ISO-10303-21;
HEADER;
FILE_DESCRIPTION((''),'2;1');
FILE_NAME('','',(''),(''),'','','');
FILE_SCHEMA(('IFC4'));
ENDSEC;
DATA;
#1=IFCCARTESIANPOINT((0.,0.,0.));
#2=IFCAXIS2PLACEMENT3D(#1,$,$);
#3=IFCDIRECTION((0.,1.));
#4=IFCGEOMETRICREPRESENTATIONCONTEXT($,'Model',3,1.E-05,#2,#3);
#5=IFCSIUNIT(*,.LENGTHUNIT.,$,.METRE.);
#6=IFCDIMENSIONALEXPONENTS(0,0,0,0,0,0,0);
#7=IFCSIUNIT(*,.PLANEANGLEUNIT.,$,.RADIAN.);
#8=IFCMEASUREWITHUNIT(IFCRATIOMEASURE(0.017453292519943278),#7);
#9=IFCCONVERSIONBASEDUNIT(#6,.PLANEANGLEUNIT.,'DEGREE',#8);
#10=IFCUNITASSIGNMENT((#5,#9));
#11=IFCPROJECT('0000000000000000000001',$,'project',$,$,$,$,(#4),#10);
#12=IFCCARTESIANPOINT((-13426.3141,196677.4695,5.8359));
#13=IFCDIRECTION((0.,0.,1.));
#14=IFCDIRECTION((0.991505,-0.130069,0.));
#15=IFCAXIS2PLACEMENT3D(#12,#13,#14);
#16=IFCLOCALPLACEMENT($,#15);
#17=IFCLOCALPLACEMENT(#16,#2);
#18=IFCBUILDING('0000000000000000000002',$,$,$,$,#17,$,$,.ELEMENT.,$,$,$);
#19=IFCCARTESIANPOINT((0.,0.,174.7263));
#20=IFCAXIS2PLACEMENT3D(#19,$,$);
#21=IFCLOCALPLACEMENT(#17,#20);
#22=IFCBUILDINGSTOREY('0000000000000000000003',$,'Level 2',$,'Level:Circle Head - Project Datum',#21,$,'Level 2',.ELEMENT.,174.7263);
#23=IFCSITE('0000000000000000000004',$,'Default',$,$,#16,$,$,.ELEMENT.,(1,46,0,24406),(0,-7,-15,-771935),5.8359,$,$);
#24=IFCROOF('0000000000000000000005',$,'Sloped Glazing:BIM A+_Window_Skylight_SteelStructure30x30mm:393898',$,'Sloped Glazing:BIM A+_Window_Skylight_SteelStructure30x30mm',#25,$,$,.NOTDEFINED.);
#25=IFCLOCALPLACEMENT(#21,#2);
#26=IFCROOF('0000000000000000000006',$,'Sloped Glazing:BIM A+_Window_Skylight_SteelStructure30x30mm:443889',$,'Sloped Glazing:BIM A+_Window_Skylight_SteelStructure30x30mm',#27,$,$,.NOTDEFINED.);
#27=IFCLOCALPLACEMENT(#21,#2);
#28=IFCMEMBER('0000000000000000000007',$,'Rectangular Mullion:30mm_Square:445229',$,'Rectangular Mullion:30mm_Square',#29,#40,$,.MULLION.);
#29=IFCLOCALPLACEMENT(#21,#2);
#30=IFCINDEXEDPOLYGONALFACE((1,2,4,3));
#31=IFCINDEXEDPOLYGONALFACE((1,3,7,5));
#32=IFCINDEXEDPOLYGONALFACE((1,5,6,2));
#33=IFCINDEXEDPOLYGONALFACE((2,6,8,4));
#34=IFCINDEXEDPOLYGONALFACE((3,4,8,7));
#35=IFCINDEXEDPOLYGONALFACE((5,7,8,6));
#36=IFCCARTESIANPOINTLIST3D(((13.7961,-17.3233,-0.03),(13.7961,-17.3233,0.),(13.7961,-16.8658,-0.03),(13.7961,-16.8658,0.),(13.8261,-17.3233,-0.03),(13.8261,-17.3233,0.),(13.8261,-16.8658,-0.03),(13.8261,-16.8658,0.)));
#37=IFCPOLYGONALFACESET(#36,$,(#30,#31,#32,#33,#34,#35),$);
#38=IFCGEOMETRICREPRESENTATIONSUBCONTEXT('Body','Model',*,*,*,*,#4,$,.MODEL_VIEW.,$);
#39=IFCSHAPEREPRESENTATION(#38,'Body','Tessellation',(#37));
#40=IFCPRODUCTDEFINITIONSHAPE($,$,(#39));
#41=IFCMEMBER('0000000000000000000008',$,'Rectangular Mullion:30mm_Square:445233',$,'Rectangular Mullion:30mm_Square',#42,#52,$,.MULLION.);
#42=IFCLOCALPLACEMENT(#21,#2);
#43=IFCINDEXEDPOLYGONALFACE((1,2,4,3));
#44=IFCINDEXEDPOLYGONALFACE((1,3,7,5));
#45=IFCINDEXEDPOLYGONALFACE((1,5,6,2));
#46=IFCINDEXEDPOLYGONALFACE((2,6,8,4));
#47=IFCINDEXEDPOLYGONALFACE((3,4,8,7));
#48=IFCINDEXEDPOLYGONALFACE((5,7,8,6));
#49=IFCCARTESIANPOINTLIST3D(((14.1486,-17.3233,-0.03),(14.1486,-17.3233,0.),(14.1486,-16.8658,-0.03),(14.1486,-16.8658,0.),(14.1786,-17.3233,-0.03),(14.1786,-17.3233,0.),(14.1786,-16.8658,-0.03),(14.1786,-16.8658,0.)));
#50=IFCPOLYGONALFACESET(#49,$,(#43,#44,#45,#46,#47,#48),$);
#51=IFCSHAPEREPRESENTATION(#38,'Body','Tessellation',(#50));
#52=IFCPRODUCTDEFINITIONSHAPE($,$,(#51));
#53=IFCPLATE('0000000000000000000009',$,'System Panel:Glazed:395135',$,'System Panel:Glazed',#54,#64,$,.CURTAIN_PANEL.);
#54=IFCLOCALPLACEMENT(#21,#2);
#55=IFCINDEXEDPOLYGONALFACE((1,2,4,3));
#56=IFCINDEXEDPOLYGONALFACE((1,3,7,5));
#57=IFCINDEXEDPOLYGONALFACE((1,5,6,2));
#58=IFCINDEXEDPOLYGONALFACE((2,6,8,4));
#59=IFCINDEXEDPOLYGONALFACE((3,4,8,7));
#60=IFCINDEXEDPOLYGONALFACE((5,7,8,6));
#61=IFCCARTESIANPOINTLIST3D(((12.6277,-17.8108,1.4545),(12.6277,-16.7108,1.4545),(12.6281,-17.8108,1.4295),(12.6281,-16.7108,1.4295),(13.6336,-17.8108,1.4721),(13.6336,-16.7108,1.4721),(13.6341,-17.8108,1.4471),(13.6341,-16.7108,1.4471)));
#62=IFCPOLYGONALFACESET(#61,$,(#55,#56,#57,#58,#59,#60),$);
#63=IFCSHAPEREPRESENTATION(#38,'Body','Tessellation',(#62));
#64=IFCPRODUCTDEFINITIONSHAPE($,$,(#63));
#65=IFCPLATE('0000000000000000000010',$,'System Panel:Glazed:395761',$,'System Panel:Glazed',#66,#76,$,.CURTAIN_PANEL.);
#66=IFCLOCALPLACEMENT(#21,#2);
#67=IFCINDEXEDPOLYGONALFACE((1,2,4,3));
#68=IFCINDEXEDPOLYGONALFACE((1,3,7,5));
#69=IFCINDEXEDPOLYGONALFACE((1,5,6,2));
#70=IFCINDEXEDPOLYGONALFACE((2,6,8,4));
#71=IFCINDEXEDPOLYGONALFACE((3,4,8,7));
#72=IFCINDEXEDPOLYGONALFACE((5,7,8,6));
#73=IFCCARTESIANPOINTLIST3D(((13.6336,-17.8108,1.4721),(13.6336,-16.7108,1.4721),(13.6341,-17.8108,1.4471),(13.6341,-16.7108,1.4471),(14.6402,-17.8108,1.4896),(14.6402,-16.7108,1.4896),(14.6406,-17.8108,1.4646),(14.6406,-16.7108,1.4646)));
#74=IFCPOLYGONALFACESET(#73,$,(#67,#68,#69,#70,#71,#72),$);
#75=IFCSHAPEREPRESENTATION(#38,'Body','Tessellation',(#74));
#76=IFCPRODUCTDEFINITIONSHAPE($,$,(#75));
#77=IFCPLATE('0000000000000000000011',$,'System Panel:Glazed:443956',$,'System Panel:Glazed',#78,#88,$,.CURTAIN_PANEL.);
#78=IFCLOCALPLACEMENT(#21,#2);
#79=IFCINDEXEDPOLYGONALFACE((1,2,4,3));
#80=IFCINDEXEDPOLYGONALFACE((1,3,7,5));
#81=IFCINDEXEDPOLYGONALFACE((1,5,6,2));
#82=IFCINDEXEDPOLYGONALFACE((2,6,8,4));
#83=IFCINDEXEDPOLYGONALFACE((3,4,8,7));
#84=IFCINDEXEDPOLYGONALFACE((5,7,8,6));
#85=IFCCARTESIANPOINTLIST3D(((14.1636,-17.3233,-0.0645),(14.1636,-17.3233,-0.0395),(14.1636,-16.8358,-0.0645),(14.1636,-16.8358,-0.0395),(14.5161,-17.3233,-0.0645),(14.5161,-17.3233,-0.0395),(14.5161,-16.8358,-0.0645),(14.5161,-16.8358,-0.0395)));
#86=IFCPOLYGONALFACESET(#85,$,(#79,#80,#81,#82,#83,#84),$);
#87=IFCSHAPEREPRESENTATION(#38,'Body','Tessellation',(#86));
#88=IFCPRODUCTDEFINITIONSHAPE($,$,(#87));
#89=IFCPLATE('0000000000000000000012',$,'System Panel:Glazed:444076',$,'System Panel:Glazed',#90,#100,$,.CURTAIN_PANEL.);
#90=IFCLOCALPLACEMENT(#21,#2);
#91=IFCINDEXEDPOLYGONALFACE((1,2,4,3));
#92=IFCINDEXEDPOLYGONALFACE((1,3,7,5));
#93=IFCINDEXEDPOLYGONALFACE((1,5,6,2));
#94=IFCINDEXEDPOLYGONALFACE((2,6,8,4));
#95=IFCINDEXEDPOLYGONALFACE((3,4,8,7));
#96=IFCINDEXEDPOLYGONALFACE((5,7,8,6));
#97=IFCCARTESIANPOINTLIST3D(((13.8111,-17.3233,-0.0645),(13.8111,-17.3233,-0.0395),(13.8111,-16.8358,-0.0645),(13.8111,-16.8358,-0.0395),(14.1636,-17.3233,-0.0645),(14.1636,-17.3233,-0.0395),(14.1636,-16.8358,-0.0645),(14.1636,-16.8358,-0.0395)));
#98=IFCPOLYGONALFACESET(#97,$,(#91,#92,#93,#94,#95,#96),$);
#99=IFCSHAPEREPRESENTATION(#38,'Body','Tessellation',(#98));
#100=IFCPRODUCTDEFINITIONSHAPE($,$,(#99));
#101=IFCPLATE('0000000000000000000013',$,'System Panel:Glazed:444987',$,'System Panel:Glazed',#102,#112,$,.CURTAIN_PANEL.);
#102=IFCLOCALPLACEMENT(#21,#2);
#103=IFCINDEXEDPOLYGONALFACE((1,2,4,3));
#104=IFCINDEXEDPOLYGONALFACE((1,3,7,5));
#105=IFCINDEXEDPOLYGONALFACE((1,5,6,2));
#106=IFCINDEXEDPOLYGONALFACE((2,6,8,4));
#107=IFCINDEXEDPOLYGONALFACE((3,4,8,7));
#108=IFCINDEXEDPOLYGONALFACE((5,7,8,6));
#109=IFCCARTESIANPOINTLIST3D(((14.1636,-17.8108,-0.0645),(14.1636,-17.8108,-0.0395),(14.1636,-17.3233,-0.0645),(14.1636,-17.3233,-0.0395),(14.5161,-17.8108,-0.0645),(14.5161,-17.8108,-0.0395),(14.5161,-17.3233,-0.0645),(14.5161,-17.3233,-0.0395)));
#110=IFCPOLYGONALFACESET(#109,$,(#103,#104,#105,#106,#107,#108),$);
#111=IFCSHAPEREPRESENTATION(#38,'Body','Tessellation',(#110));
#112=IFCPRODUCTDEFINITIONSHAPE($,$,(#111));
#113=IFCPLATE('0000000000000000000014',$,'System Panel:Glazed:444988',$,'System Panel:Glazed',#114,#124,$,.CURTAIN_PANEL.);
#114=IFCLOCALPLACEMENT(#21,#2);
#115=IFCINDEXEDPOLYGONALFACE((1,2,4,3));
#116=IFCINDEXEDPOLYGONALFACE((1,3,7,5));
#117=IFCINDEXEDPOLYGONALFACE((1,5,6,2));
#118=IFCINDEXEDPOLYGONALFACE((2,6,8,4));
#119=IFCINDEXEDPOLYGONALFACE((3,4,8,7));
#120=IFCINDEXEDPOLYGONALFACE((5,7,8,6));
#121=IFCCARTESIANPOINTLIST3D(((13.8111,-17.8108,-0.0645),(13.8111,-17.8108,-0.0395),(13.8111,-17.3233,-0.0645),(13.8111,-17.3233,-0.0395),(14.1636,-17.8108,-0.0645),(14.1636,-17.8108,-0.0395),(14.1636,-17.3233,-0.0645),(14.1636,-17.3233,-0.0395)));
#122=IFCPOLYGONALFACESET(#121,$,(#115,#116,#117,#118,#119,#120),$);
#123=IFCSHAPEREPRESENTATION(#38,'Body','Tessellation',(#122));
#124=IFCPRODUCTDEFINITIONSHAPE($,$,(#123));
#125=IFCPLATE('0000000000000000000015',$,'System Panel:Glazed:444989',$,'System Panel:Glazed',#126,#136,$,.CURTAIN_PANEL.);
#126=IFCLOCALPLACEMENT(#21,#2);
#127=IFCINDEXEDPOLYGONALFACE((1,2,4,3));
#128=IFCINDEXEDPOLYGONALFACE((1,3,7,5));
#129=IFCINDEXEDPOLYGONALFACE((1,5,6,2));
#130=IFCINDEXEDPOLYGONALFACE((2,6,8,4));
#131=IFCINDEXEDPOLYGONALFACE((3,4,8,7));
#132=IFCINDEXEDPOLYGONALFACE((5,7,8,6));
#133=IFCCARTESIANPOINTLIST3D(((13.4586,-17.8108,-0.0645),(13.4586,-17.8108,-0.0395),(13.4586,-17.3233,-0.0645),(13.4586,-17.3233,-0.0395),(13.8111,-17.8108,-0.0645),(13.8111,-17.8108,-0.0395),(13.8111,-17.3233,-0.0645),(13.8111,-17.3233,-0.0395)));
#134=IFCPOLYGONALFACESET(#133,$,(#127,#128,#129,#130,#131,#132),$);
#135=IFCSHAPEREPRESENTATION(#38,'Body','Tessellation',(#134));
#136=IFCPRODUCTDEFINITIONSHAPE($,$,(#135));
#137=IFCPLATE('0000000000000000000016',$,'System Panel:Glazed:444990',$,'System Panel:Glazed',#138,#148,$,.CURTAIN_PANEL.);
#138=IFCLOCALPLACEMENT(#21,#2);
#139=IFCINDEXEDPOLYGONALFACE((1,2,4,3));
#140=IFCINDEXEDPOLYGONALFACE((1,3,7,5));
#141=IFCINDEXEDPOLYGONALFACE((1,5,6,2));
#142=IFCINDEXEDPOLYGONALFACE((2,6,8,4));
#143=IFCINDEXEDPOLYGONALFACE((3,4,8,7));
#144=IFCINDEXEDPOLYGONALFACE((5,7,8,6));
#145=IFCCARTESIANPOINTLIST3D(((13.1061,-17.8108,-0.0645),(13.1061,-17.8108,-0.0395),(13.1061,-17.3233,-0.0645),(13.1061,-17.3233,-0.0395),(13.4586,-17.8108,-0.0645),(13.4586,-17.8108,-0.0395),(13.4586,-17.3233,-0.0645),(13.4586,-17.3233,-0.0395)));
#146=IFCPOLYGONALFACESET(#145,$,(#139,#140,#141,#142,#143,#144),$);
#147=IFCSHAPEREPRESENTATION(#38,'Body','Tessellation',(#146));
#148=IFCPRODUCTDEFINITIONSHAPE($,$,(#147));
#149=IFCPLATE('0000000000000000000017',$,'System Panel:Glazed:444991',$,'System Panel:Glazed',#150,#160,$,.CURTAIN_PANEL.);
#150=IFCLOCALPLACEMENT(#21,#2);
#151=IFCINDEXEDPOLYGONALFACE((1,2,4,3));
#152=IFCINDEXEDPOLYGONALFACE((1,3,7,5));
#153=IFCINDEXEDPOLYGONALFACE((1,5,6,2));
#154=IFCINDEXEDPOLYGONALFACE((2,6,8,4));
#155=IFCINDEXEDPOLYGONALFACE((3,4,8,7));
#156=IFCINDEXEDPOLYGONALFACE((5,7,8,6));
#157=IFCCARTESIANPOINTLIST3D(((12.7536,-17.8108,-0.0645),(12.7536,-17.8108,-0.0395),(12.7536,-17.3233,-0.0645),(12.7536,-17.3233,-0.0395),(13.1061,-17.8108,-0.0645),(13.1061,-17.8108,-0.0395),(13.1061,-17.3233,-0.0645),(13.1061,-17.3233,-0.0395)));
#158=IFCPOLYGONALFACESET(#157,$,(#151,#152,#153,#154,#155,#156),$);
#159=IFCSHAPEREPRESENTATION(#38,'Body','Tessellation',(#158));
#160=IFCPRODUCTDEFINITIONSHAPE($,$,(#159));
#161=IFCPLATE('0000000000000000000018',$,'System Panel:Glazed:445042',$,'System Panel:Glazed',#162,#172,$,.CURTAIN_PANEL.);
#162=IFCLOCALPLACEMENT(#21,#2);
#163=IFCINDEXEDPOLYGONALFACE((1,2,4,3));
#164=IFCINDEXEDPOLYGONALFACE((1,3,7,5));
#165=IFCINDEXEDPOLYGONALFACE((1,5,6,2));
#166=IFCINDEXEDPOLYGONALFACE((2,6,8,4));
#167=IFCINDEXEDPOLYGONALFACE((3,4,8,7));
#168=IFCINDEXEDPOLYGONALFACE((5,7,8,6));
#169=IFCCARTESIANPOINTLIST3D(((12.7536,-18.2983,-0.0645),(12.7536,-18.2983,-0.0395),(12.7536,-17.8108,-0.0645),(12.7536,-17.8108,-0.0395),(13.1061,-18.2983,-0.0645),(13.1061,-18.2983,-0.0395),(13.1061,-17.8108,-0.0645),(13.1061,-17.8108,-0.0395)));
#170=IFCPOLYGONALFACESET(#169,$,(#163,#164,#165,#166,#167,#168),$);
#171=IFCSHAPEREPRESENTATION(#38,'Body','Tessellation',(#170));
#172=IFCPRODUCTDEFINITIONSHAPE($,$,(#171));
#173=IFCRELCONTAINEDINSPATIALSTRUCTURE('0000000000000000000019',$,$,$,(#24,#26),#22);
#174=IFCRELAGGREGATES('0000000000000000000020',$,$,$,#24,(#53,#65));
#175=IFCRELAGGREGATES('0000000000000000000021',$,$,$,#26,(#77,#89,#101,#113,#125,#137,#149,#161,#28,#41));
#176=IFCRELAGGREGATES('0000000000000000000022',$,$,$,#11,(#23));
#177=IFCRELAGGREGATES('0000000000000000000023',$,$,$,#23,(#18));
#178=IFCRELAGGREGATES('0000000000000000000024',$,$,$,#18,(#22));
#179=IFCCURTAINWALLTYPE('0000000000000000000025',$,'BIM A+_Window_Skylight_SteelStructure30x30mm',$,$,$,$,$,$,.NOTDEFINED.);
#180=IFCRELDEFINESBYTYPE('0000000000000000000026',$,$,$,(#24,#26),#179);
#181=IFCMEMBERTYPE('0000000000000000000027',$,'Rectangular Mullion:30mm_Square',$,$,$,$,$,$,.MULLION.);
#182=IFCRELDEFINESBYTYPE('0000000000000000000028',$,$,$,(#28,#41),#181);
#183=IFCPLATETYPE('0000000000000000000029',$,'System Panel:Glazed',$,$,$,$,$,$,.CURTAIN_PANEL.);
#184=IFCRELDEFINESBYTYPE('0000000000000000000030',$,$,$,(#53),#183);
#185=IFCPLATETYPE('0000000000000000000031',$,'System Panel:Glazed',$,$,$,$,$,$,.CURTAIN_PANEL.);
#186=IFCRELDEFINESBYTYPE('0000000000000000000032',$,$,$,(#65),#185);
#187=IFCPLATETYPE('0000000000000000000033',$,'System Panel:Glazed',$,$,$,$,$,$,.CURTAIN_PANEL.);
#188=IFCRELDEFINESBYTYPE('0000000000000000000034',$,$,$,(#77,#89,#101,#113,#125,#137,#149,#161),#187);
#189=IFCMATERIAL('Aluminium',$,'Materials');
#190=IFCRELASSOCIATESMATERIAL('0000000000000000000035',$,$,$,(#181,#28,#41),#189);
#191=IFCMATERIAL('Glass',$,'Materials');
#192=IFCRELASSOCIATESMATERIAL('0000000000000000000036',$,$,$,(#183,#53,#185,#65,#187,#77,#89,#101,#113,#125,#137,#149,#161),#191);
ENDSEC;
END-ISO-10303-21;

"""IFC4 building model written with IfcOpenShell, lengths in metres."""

from ifc_helpers import new_model, entity, si_unit, converted_unit, direction, frame, origin, place, context, subcontext, project, spatial, indexed_curve, outline, extrude, source, transform, mapped, material, type_object, type_shapes, element, aggregate, save


model = new_model("IFC4")

# Units and contexts
model_context = context("Model", 3, precision=1e-05, world=origin(), true_north=direction((0.0, 1.0)))
body_context = subcontext(model_context, "Body", "Model", "MODEL_VIEW")
ifc_project = project(units=[si_unit("LENGTHUNIT", "METRE"), converted_unit("PLANEANGLEUNIT", "DEGREE", entity("IfcRatioMeasure", 0.017453292519943278), si_unit("PLANEANGLEUNIT", "RADIAN"), dimensions=[0, 0, 0, 0, 0, 0, 0])], contexts=[model_context])

# Site, building, storey
site_placement = place(None, frame((-13426.3141, 196677.4695, 5.8359), z_axis=(0.0, 0.0, 1.0), x_axis=(0.991505, -0.130069, 0.0)))
site = spatial("IfcSite", under=ifc_project, at=site_placement, Name="Default", CompositionType="ELEMENT", RefLatitude=(1, 46, 0, 24406), RefLongitude=(0, -7, -15, -771935), RefElevation=5.8359)
building_placement = place(site_placement, origin())
building = spatial("IfcBuilding", under=site, at=building_placement, CompositionType="ELEMENT")
storey_placement = place(building_placement, frame((0.0, 0.0, 174.7263)))
storey = spatial("IfcBuildingStorey", under=building, at=storey_placement, Name="Level 2", ObjectType="Level:Circle Head - Project Datum", LongName="Level 2", CompositionType="ELEMENT", Elevation=174.7263)

# Roofs, members
curtain_wall_type = type_object("IfcCurtainWallType", Name="BIM A+_Window_Skylight_SteelStructure30x30mm", PredefinedType="NOTDEFINED")
roof_1_placement = place(storey_placement, frame((0.0, 0.0, -174.7263)))
roof_1 = element("IfcRoof", 1, at=roof_1_placement, inside=storey, type_object=curtain_wall_type, Name="Sloped Glazing:BIM A+_Window_Skylight_SteelStructure30x30mm:393898", ObjectType="Sloped Glazing:BIM A+_Window_Skylight_SteelStructure30x30mm", PredefinedType="NOTDEFINED")
ifc_material_1 = material(Name="Aluminium", Category="Materials")
roof_2_placement = place(storey_placement, frame((0.0, 0.0, -174.7263)))
roof_2 = element("IfcRoof", 2, at=roof_2_placement, inside=storey, type_object=curtain_wall_type, Name="Sloped Glazing:BIM A+_Window_Skylight_SteelStructure30x30mm:443889", ObjectType="Sloped Glazing:BIM A+_Window_Skylight_SteelStructure30x30mm", PredefinedType="NOTDEFINED")
member_type_1 = type_object("IfcMemberType", Name="Rectangular Mullion:30mm_Square", PredefinedType="MULLION", material=ifc_material_1)
shared_shape_1 = source(origin(), body_context, "Body", "SweptSolid", [
    extrude(outline(indexed_curve([(-0.015, -0.015), (0.015, -0.015), (0.015, 0.015), (-0.015, 0.015), (-0.015, -0.015)], self_intersect=False)), frame((0.0, 0.0, -0.4575), z_axis=(0.0, 0.0, 1.0), x_axis=(0.0, -1.0, 0.0)), (0.0, 0.0, 1.0), 0.4575),
])
type_shapes(member_type_1, [shared_shape_1])
member_1_placement = place(roof_2_placement, frame((13.8111, -17.3233, 174.7113), z_axis=(0.0, -1.0, 0.0), x_axis=(-1.0, 0.0, 0.0)))
member_1 = element("IfcMember", 3, at=member_1_placement, type_object=member_type_1, material=ifc_material_1, Name="Rectangular Mullion:30mm_Square:445229", ObjectType="Rectangular Mullion:30mm_Square", PredefinedType="MULLION", context=body_context, shape_type="MappedRepresentation", body=[
    mapped(shared_shape_1, transform((0.0, 0.0, 0.0), scale=1.0)),
])
member_2_placement = place(roof_2_placement, frame((14.1636, -17.3233, 174.7113), z_axis=(0.0, -1.0, 0.0), x_axis=(-1.0, 0.0, 0.0)))
member_2 = element("IfcMember", 4, at=member_2_placement, type_object=member_type_1, material=ifc_material_1, Name="Rectangular Mullion:30mm_Square:445233", ObjectType="Rectangular Mullion:30mm_Square", PredefinedType="MULLION", context=body_context, shape_type="MappedRepresentation", body=[
    mapped(shared_shape_1, transform((0.0, 0.0, 0.0), scale=1.0)),
])

# Plates
ifc_material_2 = material(Name="Glass", Category="Materials")
plate_type_1 = type_object("IfcPlateType", Name="System Panel:Glazed", PredefinedType="CURTAIN_PANEL", material=ifc_material_2)
shared_shape_2 = source(origin(), body_context, "Body", "SweptSolid", [
    extrude(outline(indexed_curve([(-0.0125, -0.55), (0.0125, -0.55), (0.0125, 0.55), (-0.0125, 0.55), (-0.0125, -0.55)], self_intersect=False)), frame((0.0, 0.037, 0.0), z_axis=(0.0, 0.0, 1.0), x_axis=(0.0, 1.0, 0.0)), (0.0, 0.0, 1.0), 1.0061),
])
type_shapes(plate_type_1, [shared_shape_2])
plate_1_placement = place(roof_1_placement, frame((12.6286, -17.2608, 176.1313), z_axis=(0.999848, 0.0, 0.017452), x_axis=(0.0, 1.0, 0.0)))
plate_1 = element("IfcPlate", 5, at=plate_1_placement, type_object=plate_type_1, material=ifc_material_2, Name="System Panel:Glazed:395135", ObjectType="System Panel:Glazed", PredefinedType="CURTAIN_PANEL", context=body_context, shape_type="MappedRepresentation", body=[
    mapped(shared_shape_2, transform((0.0, 0.0, 0.0), scale=1.0)),
])
plate_type_2 = type_object("IfcPlateType", Name="System Panel:Glazed", PredefinedType="CURTAIN_PANEL", material=ifc_material_2)
shared_shape_3 = source(origin(), body_context, "Body", "SweptSolid", [
    extrude(outline(indexed_curve([(-0.0125, -0.55), (0.0125, -0.55), (0.0125, 0.55), (-0.0125, 0.55), (-0.0125, -0.55)], self_intersect=False)), frame((0.0, 0.037, 0.0), z_axis=(0.0, 0.0, 1.0), x_axis=(0.0, 1.0, 0.0)), (0.0, 0.0, 1.0), 1.0067),
])
type_shapes(plate_type_2, [shared_shape_3])
plate_2_placement = place(roof_1_placement, frame((13.6345, -17.2608, 176.1489), z_axis=(0.999848, 0.0, 0.017452), x_axis=(0.0, 1.0, 0.0)))
plate_2 = element("IfcPlate", 6, at=plate_2_placement, type_object=plate_type_2, material=ifc_material_2, Name="System Panel:Glazed:395761", ObjectType="System Panel:Glazed", PredefinedType="CURTAIN_PANEL", context=body_context, shape_type="MappedRepresentation", body=[
    mapped(shared_shape_3, transform((0.0, 0.0, 0.0), scale=1.0)),
])
aggregate(roof_1, [plate_1, plate_2])
plate_type_3 = type_object("IfcPlateType", Name="System Panel:Glazed", PredefinedType="CURTAIN_PANEL", material=ifc_material_2)
shared_shape_4 = source(origin(), body_context, "Body", "SweptSolid", [
    extrude(outline(indexed_curve([(-0.0125, -0.1762), (0.0125, -0.1762), (0.0125, 0.1762), (-0.0125, 0.1762), (-0.0125, -0.1762)], self_intersect=False)), frame((0.0, 0.037, 0.0), z_axis=(0.0, 0.0, 1.0), x_axis=(0.0, 1.0, 0.0)), (0.0, 0.0, 1.0), 0.4875),
])
type_shapes(plate_type_3, [shared_shape_4])
plate_3_placement = place(roof_2_placement, frame((14.3398, -16.8358, 174.7113), z_axis=(0.0, -1.0, 0.0), x_axis=(-1.0, 0.0, 0.0)))
plate_3 = element("IfcPlate", 7, at=plate_3_placement, type_object=plate_type_3, material=ifc_material_2, Name="System Panel:Glazed:443956", ObjectType="System Panel:Glazed", PredefinedType="CURTAIN_PANEL", context=body_context, shape_type="MappedRepresentation", body=[
    mapped(shared_shape_4, transform((0.0, 0.0, 0.0), scale=1.0)),
])
plate_4_placement = place(roof_2_placement, frame((13.9873, -16.8358, 174.7113), z_axis=(0.0, -1.0, 0.0), x_axis=(-1.0, 0.0, 0.0)))
plate_4 = element("IfcPlate", 8, at=plate_4_placement, type_object=plate_type_3, material=ifc_material_2, Name="System Panel:Glazed:444076", ObjectType="System Panel:Glazed", PredefinedType="CURTAIN_PANEL", context=body_context, shape_type="MappedRepresentation", body=[
    mapped(shared_shape_4, transform((0.0, 0.0, 0.0), scale=1.0)),
])
plate_5_placement = place(roof_2_placement, frame((14.3398, -17.3233, 174.7113), z_axis=(0.0, -1.0, 0.0), x_axis=(-1.0, 0.0, 0.0)))
plate_5 = element("IfcPlate", 9, at=plate_5_placement, type_object=plate_type_3, material=ifc_material_2, Name="System Panel:Glazed:444987", ObjectType="System Panel:Glazed", PredefinedType="CURTAIN_PANEL", context=body_context, shape_type="MappedRepresentation", body=[
    mapped(shared_shape_4, transform((0.0, 0.0, 0.0), scale=1.0)),
])
plate_6_placement = place(roof_2_placement, frame((13.9873, -17.3233, 174.7113), z_axis=(0.0, -1.0, 0.0), x_axis=(-1.0, 0.0, 0.0)))
plate_6 = element("IfcPlate", 10, at=plate_6_placement, type_object=plate_type_3, material=ifc_material_2, Name="System Panel:Glazed:444988", ObjectType="System Panel:Glazed", PredefinedType="CURTAIN_PANEL", context=body_context, shape_type="MappedRepresentation", body=[
    mapped(shared_shape_4, transform((0.0, 0.0, 0.0), scale=1.0)),
])
plate_7_placement = place(roof_2_placement, frame((13.6348, -17.3233, 174.7113), z_axis=(0.0, -1.0, 0.0), x_axis=(-1.0, 0.0, 0.0)))
plate_7 = element("IfcPlate", 11, at=plate_7_placement, type_object=plate_type_3, material=ifc_material_2, Name="System Panel:Glazed:444989", ObjectType="System Panel:Glazed", PredefinedType="CURTAIN_PANEL", context=body_context, shape_type="MappedRepresentation", body=[
    mapped(shared_shape_4, transform((0.0, 0.0, 0.0), scale=1.0)),
])
plate_8_placement = place(roof_2_placement, frame((13.2823, -17.3233, 174.7113), z_axis=(0.0, -1.0, 0.0), x_axis=(-1.0, 0.0, 0.0)))
plate_8 = element("IfcPlate", 12, at=plate_8_placement, type_object=plate_type_3, material=ifc_material_2, Name="System Panel:Glazed:444990", ObjectType="System Panel:Glazed", PredefinedType="CURTAIN_PANEL", context=body_context, shape_type="MappedRepresentation", body=[
    mapped(shared_shape_4, transform((0.0, 0.0, 0.0), scale=1.0)),
])
plate_9_placement = place(roof_2_placement, frame((12.9298, -17.3233, 174.7113), z_axis=(0.0, -1.0, 0.0), x_axis=(-1.0, 0.0, 0.0)))
plate_9 = element("IfcPlate", 13, at=plate_9_placement, type_object=plate_type_3, material=ifc_material_2, Name="System Panel:Glazed:444991", ObjectType="System Panel:Glazed", PredefinedType="CURTAIN_PANEL", context=body_context, shape_type="MappedRepresentation", body=[
    mapped(shared_shape_4, transform((0.0, 0.0, 0.0), scale=1.0)),
])
plate_10_placement = place(roof_2_placement, frame((12.9298, -17.8108, 174.7113), z_axis=(0.0, -1.0, 0.0), x_axis=(-1.0, 0.0, 0.0)))
plate_10 = element("IfcPlate", 14, at=plate_10_placement, type_object=plate_type_3, material=ifc_material_2, Name="System Panel:Glazed:445042", ObjectType="System Panel:Glazed", PredefinedType="CURTAIN_PANEL", context=body_context, shape_type="MappedRepresentation", body=[
    mapped(shared_shape_4, transform((0.0, 0.0, 0.0), scale=1.0)),
])
aggregate(roof_2, [plate_3, plate_4, plate_5, plate_6, plate_7, plate_8, plate_9, plate_10, member_1, member_2])

save(model, "model.ifc")
